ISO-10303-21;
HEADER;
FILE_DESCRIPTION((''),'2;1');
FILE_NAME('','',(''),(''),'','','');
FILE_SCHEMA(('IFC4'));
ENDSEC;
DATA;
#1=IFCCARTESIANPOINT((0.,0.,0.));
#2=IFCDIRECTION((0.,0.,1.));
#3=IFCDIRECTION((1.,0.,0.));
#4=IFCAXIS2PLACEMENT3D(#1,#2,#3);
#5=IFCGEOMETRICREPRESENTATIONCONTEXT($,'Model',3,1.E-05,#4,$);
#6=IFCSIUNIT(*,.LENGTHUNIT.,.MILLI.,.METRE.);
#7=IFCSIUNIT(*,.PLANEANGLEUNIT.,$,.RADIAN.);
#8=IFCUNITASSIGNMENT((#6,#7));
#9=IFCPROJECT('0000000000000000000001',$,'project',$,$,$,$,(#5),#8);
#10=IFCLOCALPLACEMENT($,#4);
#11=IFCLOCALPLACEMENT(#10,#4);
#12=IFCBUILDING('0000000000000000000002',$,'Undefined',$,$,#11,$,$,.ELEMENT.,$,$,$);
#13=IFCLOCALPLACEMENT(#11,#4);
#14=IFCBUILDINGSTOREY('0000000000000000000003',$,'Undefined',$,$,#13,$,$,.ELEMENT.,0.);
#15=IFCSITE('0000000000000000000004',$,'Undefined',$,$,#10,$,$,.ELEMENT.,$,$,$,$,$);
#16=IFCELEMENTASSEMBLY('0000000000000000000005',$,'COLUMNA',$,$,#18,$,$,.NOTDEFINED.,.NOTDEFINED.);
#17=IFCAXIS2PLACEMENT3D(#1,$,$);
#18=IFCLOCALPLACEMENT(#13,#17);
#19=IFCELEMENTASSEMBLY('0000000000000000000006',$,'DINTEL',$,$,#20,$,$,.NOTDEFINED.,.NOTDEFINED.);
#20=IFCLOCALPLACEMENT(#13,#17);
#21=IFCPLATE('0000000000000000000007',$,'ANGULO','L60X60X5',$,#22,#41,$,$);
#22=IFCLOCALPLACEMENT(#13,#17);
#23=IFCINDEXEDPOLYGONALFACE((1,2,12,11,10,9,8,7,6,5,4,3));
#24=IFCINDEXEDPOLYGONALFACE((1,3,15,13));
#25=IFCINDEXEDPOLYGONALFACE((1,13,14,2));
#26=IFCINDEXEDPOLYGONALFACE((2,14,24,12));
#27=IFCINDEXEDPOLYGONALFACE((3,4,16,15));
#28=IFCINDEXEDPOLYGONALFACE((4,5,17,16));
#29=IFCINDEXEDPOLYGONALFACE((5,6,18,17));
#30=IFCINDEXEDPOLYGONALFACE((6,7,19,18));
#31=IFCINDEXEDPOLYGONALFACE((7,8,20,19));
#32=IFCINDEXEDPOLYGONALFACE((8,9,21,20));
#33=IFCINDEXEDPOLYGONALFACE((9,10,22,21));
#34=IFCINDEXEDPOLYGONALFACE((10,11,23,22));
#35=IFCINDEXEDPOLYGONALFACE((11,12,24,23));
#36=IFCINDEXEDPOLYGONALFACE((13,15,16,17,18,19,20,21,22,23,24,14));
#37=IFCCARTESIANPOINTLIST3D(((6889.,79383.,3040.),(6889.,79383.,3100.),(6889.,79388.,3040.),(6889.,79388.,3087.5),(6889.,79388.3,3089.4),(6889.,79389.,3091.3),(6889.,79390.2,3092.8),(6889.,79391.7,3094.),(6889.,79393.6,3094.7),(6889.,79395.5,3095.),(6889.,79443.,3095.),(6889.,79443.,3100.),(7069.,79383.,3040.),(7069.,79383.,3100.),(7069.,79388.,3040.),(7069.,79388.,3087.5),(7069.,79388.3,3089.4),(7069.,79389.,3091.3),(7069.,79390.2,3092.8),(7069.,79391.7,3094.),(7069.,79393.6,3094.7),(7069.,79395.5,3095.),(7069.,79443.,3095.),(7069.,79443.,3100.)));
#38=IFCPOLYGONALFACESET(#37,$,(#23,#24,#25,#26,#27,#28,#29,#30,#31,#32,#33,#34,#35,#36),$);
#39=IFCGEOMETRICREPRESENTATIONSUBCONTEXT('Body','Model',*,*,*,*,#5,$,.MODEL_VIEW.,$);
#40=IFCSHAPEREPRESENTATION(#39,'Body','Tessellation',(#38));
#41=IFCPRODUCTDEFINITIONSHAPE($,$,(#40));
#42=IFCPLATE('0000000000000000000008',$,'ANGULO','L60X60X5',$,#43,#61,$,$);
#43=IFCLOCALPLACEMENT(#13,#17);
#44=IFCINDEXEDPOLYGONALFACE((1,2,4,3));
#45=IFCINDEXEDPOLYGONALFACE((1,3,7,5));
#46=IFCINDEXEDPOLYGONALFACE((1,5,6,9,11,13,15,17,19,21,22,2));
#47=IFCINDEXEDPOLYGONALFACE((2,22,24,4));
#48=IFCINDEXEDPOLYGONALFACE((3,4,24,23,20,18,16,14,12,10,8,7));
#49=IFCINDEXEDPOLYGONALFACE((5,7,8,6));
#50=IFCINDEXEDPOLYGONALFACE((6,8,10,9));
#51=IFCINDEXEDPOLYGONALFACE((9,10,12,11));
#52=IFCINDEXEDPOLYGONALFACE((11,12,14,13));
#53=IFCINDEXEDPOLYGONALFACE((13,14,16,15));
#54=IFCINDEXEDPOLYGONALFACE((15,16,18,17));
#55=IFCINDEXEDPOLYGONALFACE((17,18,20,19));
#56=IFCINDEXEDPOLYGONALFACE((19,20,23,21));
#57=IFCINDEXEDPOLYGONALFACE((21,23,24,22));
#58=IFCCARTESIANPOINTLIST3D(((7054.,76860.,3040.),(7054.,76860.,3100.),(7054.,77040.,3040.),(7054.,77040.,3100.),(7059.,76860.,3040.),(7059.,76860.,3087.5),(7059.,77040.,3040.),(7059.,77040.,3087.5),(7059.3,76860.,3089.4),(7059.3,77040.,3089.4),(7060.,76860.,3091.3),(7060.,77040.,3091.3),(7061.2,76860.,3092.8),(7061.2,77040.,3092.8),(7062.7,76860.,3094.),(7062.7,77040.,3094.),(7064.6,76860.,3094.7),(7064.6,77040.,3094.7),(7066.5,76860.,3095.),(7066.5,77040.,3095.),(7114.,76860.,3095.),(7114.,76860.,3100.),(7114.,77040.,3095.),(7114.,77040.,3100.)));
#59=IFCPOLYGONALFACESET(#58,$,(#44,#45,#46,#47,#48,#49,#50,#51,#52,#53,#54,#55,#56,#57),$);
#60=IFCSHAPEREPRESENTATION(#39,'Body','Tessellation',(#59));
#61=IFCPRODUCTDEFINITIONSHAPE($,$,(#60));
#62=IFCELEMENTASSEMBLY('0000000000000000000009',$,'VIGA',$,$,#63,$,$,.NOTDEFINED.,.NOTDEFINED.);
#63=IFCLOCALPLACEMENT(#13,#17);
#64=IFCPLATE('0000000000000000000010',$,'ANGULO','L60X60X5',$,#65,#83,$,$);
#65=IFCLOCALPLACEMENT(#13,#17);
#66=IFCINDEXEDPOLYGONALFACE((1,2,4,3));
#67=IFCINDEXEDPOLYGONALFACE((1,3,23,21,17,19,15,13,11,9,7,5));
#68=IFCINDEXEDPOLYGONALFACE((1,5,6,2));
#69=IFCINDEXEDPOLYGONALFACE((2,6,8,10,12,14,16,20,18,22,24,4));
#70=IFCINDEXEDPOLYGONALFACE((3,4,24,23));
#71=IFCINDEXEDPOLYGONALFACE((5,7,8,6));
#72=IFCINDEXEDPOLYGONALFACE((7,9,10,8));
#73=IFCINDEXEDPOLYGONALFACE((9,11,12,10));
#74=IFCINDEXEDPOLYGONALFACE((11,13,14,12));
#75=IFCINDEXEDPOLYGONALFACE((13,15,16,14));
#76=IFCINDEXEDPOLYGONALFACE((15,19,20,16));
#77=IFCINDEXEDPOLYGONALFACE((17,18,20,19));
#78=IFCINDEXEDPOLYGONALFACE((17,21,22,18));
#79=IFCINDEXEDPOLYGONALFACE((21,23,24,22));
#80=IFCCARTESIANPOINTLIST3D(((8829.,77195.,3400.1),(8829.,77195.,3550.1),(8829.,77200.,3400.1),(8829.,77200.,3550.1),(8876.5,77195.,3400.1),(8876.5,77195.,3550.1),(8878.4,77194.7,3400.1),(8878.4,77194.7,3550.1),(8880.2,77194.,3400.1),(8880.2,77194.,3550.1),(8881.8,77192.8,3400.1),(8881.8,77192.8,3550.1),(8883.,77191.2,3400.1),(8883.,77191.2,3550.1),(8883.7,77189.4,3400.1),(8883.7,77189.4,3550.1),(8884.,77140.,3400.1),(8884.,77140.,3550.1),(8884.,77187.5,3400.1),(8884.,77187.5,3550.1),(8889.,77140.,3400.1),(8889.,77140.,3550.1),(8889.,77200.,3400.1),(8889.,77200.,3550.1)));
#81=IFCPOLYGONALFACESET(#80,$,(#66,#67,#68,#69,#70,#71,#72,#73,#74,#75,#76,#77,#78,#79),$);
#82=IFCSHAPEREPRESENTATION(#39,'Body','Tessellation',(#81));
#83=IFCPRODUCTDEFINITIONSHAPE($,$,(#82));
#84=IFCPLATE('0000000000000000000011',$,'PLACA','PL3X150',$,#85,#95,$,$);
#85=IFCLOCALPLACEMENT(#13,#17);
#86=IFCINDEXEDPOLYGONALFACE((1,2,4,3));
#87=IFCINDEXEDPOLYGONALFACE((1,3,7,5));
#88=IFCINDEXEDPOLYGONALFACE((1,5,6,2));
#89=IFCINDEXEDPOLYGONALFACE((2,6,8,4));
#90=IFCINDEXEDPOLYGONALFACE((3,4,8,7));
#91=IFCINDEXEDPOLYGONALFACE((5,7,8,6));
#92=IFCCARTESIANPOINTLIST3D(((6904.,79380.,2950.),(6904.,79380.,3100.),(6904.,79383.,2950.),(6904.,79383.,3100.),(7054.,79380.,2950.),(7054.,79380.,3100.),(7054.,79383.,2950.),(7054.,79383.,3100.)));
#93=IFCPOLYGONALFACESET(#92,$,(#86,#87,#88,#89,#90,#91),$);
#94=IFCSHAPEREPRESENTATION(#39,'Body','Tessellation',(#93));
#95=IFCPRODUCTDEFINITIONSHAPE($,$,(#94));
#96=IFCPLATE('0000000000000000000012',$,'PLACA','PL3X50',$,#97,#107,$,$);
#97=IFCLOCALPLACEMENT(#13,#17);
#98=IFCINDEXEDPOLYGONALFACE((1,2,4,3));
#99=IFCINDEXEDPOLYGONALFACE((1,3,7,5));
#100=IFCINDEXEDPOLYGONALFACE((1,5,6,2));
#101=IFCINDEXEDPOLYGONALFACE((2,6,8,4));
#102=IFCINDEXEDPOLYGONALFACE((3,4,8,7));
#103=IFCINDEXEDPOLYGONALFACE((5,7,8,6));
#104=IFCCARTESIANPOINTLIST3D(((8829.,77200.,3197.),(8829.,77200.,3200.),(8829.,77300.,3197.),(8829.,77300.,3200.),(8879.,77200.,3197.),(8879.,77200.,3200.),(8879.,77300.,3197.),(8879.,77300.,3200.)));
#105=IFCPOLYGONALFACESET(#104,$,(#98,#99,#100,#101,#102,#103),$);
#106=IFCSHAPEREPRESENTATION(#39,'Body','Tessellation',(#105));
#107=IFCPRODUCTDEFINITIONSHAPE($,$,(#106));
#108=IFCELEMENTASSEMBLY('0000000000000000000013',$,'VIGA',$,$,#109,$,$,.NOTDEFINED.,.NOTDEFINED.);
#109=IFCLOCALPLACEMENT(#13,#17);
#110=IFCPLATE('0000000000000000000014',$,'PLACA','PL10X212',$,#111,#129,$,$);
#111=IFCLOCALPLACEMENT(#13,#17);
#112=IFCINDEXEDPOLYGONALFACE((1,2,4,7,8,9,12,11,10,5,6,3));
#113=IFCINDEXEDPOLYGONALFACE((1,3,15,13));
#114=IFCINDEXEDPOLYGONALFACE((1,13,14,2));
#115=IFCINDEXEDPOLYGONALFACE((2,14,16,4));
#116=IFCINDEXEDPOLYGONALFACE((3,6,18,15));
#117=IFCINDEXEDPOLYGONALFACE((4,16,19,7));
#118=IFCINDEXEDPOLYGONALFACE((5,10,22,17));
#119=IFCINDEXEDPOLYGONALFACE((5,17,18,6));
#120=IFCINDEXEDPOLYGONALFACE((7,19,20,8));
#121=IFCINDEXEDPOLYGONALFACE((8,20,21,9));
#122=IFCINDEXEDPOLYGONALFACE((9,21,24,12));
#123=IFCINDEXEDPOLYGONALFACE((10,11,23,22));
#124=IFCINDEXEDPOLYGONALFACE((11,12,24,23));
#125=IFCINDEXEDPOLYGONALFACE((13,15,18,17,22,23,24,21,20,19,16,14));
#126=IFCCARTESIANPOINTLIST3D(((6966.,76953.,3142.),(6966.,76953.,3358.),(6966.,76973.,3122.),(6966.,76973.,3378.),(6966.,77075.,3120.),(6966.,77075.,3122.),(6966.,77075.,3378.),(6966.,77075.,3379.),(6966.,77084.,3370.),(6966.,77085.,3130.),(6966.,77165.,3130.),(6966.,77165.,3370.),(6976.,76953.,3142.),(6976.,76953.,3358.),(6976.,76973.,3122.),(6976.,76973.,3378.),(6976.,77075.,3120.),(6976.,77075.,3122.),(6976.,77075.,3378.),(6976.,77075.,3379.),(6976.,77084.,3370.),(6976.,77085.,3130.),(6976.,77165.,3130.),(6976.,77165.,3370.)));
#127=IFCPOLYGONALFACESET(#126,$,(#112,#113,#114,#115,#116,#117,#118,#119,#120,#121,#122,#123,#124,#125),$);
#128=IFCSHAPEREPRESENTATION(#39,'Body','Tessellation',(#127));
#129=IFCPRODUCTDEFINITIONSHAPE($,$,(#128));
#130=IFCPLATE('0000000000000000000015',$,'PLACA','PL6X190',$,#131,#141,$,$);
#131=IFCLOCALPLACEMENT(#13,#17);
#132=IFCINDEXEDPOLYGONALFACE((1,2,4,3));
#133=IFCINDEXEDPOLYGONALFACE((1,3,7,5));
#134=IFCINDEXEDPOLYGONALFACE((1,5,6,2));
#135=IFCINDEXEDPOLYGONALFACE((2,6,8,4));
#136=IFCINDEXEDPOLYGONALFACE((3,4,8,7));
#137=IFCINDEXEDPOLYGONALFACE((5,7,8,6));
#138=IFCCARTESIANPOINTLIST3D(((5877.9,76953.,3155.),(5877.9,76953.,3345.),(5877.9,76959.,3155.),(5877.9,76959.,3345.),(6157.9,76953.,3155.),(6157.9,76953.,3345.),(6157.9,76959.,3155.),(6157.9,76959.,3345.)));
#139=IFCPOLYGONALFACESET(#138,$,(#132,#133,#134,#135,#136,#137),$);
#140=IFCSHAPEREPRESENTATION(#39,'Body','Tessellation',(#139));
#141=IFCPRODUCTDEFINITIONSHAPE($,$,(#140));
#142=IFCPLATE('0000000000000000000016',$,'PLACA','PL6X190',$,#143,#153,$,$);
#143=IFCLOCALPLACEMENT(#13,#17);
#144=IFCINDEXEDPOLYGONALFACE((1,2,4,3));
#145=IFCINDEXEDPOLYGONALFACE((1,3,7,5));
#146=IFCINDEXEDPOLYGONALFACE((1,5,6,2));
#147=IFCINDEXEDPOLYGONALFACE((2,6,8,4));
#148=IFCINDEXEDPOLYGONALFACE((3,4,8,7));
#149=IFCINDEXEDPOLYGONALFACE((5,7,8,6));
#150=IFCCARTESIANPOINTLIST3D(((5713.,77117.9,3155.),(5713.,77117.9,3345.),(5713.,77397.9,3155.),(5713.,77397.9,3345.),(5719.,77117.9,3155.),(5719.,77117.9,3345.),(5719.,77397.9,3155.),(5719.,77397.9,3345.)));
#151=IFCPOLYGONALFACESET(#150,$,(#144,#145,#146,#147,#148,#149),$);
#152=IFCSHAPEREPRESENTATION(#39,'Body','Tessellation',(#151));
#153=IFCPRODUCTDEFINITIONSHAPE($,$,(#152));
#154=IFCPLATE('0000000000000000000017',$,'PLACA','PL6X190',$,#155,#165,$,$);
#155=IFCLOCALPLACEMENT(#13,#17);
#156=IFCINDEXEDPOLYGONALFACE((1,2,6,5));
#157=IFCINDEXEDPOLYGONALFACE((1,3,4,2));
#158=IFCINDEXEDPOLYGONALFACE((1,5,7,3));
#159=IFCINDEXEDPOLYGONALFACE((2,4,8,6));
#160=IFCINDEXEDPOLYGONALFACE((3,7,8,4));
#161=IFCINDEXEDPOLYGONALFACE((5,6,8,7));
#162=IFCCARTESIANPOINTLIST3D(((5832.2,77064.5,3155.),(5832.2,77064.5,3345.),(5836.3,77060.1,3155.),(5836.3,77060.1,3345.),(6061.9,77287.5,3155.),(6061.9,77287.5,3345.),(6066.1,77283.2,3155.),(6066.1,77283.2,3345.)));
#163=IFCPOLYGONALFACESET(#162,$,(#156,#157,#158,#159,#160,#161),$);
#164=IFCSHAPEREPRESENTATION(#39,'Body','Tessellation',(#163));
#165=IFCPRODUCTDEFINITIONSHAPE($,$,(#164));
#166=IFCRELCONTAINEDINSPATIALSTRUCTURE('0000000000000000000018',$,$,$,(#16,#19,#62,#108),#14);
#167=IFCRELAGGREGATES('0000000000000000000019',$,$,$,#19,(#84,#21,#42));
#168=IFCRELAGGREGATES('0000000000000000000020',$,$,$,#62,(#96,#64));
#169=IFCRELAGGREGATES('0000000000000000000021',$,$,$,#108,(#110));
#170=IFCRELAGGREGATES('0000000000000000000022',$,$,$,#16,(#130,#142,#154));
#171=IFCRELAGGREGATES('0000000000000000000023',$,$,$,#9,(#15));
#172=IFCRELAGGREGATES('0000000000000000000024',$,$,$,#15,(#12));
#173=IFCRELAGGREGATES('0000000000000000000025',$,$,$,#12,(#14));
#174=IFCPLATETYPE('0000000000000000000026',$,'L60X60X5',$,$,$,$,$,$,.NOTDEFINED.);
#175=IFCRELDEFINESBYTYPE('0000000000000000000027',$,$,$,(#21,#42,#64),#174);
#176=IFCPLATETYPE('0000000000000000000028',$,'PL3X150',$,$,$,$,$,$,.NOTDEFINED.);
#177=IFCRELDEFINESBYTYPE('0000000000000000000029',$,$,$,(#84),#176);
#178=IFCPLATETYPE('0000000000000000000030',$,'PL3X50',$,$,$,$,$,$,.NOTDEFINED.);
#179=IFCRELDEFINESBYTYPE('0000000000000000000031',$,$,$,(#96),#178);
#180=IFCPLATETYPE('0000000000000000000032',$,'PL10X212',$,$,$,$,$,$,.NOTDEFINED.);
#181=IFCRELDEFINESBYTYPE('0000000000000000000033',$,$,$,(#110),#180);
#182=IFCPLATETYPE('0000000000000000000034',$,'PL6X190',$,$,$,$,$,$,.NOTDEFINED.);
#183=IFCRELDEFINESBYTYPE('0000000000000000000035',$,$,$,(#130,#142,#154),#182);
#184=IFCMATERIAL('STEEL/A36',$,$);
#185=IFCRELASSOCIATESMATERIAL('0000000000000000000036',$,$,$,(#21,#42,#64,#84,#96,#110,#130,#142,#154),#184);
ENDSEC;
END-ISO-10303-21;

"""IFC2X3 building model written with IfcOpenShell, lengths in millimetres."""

from ifc_helpers import new_model, si_unit, frame, origin_with_axes, origin_2d_with_axis, place, context, subcontext, project, spatial, polyline, l_section, outline, extrude, material, type_object, element, aggregate, save


model = new_model("IFC2X3")

# Units and contexts
model_context = context("Model", 3, precision=1e-05, world=origin_with_axes())
body_context = subcontext(model_context, "Body", "Model", "MODEL_VIEW")
ifc_project = project(units=[si_unit("LENGTHUNIT", "METRE", prefix="MILLI"), si_unit("PLANEANGLEUNIT", "RADIAN")], contexts=[model_context])

# Site, building, storey
site_placement = place(None, origin_with_axes())
site = spatial("IfcSite", under=ifc_project, at=site_placement, Name="Undefined", CompositionType="ELEMENT")
building_placement = place(site_placement, origin_with_axes())
building = spatial("IfcBuilding", under=site, at=building_placement, Name="Undefined", CompositionType="ELEMENT")
storey_placement = place(building_placement, origin_with_axes())
storey = spatial("IfcBuildingStorey", under=building, at=storey_placement, Name="Undefined", CompositionType="ELEMENT", Elevation=0.0)

# Element assembly
assembly_1_placement = place(storey_placement, origin_with_axes())
assembly_1 = element("IfcElementAssembly", 1, at=assembly_1_placement, inside=storey, Name="COLUMNA", AssemblyPlace="NOTDEFINED", PredefinedType="NOTDEFINED")
ifc_material_1 = material(Name="STEEL/A36")

# Element assembly, plates
assembly_2_placement = place(storey_placement, origin_with_axes())
assembly_2 = element("IfcElementAssembly", 2, at=assembly_2_placement, inside=storey, Name="DINTEL", AssemblyPlace="NOTDEFINED", PredefinedType="NOTDEFINED")
plate_type_1 = type_object("IfcPlateType", Name="L60X60X5", PredefinedType="NOTDEFINED")
plate_1_placement = place(assembly_2_placement, frame((6889.0, 79413.0, 3070.0), z_axis=(0.0, 0.0, -1.0), x_axis=(1.0, 0.0, 0.0)))
plate_1 = element("IfcPlate", 3, at=plate_1_placement, type_object=plate_type_1, material=ifc_material_1, Name="ANGULO", Description="L60X60X5", context=body_context, shape_type="SweptSolid", body=[
    extrude(l_section(Depth=60.0, Width=60.0, Thickness=5.0, FilletRadius=7.5, at=origin_2d_with_axis()), frame((180.0, 0.0, 0.0), z_axis=(-1.0, 0.0, 0.0), x_axis=(0.0, -1.0, 0.0)), (0.0, 0.0, 1.0), 180.0),
])
plate_2_placement = place(assembly_2_placement, frame((7084.0, 77040.0, 3070.0), z_axis=(0.0, 0.0, -1.0), x_axis=(0.0, -1.0, 0.0)))
plate_2 = element("IfcPlate", 4, at=plate_2_placement, type_object=plate_type_1, material=ifc_material_1, Name="ANGULO", Description="L60X60X5", context=body_context, shape_type="SweptSolid", body=[
    extrude(l_section(Depth=60.0, Width=60.0, Thickness=5.0, FilletRadius=7.5, at=origin_2d_with_axis()), frame((180.0, 0.0, 0.0), z_axis=(-1.0, 0.0, 0.0), x_axis=(0.0, -1.0, 0.0)), (0.0, 0.0, 1.0), 180.0),
])

# Element assembly, plate
assembly_3_placement = place(storey_placement, origin_with_axes())
assembly_3 = element("IfcElementAssembly", 5, at=assembly_3_placement, inside=storey, Name="VIGA", AssemblyPlace="NOTDEFINED", PredefinedType="NOTDEFINED")
plate_3_placement = place(assembly_3_placement, frame((8859.0, 77170.0, 3400.1), z_axis=(-1.0, 0.0, 0.0), x_axis=(0.0, 0.0, 1.0)))
plate_3 = element("IfcPlate", 6, at=plate_3_placement, type_object=plate_type_1, material=ifc_material_1, Name="ANGULO", Description="L60X60X5", context=body_context, shape_type="SweptSolid", body=[
    extrude(l_section(Depth=60.0, Width=60.0, Thickness=5.0, FilletRadius=7.5, at=origin_2d_with_axis()), frame((150.0, 0.0, 0.0), z_axis=(-1.0, 0.0, 0.0), x_axis=(0.0, -1.0, 0.0)), (0.0, 0.0, 1.0), 150.0),
])

# Plates
plate_type_2 = type_object("IfcPlateType", Name="PL3X150", PredefinedType="NOTDEFINED")
plate_4_placement = place(assembly_2_placement, frame((6904.0, 79381.5, 2950.0), z_axis=(0.0, -1.0, 0.0), x_axis=(1.0, 0.0, 0.0)))
plate_4 = element("IfcPlate", 7, at=plate_4_placement, type_object=plate_type_2, material=ifc_material_1, Name="PLACA", Description="PL3X150", context=body_context, shape_type="SweptSolid", body=[
    extrude(outline(polyline([(0.0, 0.0), (150.0, 0.0), (150.0, 150.0), (0.0, 150.0), (0.0, 0.0)])), frame((0.0, 0.0, -1.5), z_axis=(0.0, 0.0, 1.0), x_axis=(1.0, 0.0, 0.0)), (0.0, 0.0, 1.0), 3.0),
])
aggregate(assembly_2, [plate_4, plate_1, plate_2])
plate_type_3 = type_object("IfcPlateType", Name="PL3X50", PredefinedType="NOTDEFINED")
plate_5_placement = place(assembly_3_placement, frame((8829.0, 77200.0, 3198.5), z_axis=(0.0, 0.0, 1.0), x_axis=(1.0, 0.0, 0.0)))
plate_5 = element("IfcPlate", 8, at=plate_5_placement, type_object=plate_type_3, material=ifc_material_1, Name="PLACA", Description="PL3X50", context=body_context, shape_type="SweptSolid", body=[
    extrude(outline(polyline([(0.0, 0.0), (50.0, 0.0), (50.0, 100.0), (0.0, 100.0), (0.0, 0.0)])), frame((0.0, 0.0, -1.5), z_axis=(0.0, 0.0, 1.0), x_axis=(1.0, 0.0, 0.0)), (0.0, 0.0, 1.0), 3.0),
])
aggregate(assembly_3, [plate_5, plate_3])

# Element assembly, plate
assembly_4_placement = place(storey_placement, origin_with_axes())
assembly_4 = element("IfcElementAssembly", 9, at=assembly_4_placement, inside=storey, Name="VIGA", AssemblyPlace="NOTDEFINED", PredefinedType="NOTDEFINED")
plate_type_4 = type_object("IfcPlateType", Name="PL10X212", PredefinedType="NOTDEFINED")
plate_6_placement = place(assembly_4_placement, frame((6971.0, 76953.0, 3142.0), z_axis=(1.0, 0.0, 0.0), x_axis=(0.0, 0.707107, -0.707107)))
plate_6 = element("IfcPlate", 10, at=plate_6_placement, type_object=plate_type_4, material=ifc_material_1, Name="PLACA", Description="PL10X212", context=body_context, shape_type="SweptSolid", body=[
    extrude(outline(polyline([(0.0, 0.0), (28.3, 0.0), (100.4, 72.1), (101.8, 70.7), (101.8, 84.9), (158.4, 141.4), (-11.3, 311.1), (-68.6, 253.9), (-81.3, 253.9), (-80.6, 253.1), (-152.7, 181.0), (-152.7, 152.7), (0.0, 0.0)])), frame((0.0, 0.0, -5.0), z_axis=(0.0, 0.0, 1.0), x_axis=(1.0, 0.0, 0.0)), (0.0, 0.0, 1.0), 10.0),
])
aggregate(assembly_4, [plate_6])

# Plates
plate_type_5 = type_object("IfcPlateType", Name="PL6X190", PredefinedType="NOTDEFINED")
plate_7_placement = place(assembly_1_placement, frame((6157.9, 76956.0, 3250.0), z_axis=(0.0, 1.0, 0.0), x_axis=(-1.0, 0.0, 0.0)))
plate_7 = element("IfcPlate", 11, at=plate_7_placement, type_object=plate_type_5, material=ifc_material_1, Name="PLACA", Description="PL6X190", context=body_context, shape_type="SweptSolid", body=[
    extrude(outline(polyline([(0.0, -95.0), (0.0, 95.0), (280.0, 95.0), (280.0, -95.0), (0.0, -95.0)])), frame((0.0, 0.0, -3.0), z_axis=(0.0, 0.0, 1.0), x_axis=(1.0, 0.0, 0.0)), (0.0, 0.0, 1.0), 6.0),
])
plate_8_placement = place(assembly_1_placement, frame((5716.0, 77397.9, 3250.0), z_axis=(-1.0, 0.0, 0.0), x_axis=(0.0, -1.0, 0.0)))
plate_8 = element("IfcPlate", 12, at=plate_8_placement, type_object=plate_type_5, material=ifc_material_1, Name="PLACA", Description="PL6X190", context=body_context, shape_type="SweptSolid", body=[
    extrude(outline(polyline([(0.0, -95.0), (0.0, 95.0), (280.0, 95.0), (280.0, -95.0), (0.0, -95.0)])), frame((0.0, 0.0, -3.0), z_axis=(0.0, 0.0, 1.0), x_axis=(1.0, 0.0, 0.0)), (0.0, 0.0, 1.0), 6.0),
])
plate_9_placement = place(assembly_1_placement, frame((6064.0, 77285.4, 3250.0), z_axis=(-0.696652, 0.717409, 0.0), x_axis=(-0.717409, -0.696652, 0.0)))
plate_9 = element("IfcPlate", 13, at=plate_9_placement, type_object=plate_type_5, material=ifc_material_1, Name="PLACA", Description="PL6X190", context=body_context, shape_type="SweptSolid", body=[
    extrude(outline(polyline([(0.0, -95.0), (0.0, 95.0), (320.2, 95.0), (320.2, -95.0), (0.0, -95.0)])), frame((0.0, 0.0, -3.0), z_axis=(0.0, 0.0, 1.0), x_axis=(1.0, 0.0, 0.0)), (0.0, 0.0, 1.0), 6.0),
])

aggregate(assembly_1, [plate_7, plate_8, plate_9])

save(model, "model.ifc")
